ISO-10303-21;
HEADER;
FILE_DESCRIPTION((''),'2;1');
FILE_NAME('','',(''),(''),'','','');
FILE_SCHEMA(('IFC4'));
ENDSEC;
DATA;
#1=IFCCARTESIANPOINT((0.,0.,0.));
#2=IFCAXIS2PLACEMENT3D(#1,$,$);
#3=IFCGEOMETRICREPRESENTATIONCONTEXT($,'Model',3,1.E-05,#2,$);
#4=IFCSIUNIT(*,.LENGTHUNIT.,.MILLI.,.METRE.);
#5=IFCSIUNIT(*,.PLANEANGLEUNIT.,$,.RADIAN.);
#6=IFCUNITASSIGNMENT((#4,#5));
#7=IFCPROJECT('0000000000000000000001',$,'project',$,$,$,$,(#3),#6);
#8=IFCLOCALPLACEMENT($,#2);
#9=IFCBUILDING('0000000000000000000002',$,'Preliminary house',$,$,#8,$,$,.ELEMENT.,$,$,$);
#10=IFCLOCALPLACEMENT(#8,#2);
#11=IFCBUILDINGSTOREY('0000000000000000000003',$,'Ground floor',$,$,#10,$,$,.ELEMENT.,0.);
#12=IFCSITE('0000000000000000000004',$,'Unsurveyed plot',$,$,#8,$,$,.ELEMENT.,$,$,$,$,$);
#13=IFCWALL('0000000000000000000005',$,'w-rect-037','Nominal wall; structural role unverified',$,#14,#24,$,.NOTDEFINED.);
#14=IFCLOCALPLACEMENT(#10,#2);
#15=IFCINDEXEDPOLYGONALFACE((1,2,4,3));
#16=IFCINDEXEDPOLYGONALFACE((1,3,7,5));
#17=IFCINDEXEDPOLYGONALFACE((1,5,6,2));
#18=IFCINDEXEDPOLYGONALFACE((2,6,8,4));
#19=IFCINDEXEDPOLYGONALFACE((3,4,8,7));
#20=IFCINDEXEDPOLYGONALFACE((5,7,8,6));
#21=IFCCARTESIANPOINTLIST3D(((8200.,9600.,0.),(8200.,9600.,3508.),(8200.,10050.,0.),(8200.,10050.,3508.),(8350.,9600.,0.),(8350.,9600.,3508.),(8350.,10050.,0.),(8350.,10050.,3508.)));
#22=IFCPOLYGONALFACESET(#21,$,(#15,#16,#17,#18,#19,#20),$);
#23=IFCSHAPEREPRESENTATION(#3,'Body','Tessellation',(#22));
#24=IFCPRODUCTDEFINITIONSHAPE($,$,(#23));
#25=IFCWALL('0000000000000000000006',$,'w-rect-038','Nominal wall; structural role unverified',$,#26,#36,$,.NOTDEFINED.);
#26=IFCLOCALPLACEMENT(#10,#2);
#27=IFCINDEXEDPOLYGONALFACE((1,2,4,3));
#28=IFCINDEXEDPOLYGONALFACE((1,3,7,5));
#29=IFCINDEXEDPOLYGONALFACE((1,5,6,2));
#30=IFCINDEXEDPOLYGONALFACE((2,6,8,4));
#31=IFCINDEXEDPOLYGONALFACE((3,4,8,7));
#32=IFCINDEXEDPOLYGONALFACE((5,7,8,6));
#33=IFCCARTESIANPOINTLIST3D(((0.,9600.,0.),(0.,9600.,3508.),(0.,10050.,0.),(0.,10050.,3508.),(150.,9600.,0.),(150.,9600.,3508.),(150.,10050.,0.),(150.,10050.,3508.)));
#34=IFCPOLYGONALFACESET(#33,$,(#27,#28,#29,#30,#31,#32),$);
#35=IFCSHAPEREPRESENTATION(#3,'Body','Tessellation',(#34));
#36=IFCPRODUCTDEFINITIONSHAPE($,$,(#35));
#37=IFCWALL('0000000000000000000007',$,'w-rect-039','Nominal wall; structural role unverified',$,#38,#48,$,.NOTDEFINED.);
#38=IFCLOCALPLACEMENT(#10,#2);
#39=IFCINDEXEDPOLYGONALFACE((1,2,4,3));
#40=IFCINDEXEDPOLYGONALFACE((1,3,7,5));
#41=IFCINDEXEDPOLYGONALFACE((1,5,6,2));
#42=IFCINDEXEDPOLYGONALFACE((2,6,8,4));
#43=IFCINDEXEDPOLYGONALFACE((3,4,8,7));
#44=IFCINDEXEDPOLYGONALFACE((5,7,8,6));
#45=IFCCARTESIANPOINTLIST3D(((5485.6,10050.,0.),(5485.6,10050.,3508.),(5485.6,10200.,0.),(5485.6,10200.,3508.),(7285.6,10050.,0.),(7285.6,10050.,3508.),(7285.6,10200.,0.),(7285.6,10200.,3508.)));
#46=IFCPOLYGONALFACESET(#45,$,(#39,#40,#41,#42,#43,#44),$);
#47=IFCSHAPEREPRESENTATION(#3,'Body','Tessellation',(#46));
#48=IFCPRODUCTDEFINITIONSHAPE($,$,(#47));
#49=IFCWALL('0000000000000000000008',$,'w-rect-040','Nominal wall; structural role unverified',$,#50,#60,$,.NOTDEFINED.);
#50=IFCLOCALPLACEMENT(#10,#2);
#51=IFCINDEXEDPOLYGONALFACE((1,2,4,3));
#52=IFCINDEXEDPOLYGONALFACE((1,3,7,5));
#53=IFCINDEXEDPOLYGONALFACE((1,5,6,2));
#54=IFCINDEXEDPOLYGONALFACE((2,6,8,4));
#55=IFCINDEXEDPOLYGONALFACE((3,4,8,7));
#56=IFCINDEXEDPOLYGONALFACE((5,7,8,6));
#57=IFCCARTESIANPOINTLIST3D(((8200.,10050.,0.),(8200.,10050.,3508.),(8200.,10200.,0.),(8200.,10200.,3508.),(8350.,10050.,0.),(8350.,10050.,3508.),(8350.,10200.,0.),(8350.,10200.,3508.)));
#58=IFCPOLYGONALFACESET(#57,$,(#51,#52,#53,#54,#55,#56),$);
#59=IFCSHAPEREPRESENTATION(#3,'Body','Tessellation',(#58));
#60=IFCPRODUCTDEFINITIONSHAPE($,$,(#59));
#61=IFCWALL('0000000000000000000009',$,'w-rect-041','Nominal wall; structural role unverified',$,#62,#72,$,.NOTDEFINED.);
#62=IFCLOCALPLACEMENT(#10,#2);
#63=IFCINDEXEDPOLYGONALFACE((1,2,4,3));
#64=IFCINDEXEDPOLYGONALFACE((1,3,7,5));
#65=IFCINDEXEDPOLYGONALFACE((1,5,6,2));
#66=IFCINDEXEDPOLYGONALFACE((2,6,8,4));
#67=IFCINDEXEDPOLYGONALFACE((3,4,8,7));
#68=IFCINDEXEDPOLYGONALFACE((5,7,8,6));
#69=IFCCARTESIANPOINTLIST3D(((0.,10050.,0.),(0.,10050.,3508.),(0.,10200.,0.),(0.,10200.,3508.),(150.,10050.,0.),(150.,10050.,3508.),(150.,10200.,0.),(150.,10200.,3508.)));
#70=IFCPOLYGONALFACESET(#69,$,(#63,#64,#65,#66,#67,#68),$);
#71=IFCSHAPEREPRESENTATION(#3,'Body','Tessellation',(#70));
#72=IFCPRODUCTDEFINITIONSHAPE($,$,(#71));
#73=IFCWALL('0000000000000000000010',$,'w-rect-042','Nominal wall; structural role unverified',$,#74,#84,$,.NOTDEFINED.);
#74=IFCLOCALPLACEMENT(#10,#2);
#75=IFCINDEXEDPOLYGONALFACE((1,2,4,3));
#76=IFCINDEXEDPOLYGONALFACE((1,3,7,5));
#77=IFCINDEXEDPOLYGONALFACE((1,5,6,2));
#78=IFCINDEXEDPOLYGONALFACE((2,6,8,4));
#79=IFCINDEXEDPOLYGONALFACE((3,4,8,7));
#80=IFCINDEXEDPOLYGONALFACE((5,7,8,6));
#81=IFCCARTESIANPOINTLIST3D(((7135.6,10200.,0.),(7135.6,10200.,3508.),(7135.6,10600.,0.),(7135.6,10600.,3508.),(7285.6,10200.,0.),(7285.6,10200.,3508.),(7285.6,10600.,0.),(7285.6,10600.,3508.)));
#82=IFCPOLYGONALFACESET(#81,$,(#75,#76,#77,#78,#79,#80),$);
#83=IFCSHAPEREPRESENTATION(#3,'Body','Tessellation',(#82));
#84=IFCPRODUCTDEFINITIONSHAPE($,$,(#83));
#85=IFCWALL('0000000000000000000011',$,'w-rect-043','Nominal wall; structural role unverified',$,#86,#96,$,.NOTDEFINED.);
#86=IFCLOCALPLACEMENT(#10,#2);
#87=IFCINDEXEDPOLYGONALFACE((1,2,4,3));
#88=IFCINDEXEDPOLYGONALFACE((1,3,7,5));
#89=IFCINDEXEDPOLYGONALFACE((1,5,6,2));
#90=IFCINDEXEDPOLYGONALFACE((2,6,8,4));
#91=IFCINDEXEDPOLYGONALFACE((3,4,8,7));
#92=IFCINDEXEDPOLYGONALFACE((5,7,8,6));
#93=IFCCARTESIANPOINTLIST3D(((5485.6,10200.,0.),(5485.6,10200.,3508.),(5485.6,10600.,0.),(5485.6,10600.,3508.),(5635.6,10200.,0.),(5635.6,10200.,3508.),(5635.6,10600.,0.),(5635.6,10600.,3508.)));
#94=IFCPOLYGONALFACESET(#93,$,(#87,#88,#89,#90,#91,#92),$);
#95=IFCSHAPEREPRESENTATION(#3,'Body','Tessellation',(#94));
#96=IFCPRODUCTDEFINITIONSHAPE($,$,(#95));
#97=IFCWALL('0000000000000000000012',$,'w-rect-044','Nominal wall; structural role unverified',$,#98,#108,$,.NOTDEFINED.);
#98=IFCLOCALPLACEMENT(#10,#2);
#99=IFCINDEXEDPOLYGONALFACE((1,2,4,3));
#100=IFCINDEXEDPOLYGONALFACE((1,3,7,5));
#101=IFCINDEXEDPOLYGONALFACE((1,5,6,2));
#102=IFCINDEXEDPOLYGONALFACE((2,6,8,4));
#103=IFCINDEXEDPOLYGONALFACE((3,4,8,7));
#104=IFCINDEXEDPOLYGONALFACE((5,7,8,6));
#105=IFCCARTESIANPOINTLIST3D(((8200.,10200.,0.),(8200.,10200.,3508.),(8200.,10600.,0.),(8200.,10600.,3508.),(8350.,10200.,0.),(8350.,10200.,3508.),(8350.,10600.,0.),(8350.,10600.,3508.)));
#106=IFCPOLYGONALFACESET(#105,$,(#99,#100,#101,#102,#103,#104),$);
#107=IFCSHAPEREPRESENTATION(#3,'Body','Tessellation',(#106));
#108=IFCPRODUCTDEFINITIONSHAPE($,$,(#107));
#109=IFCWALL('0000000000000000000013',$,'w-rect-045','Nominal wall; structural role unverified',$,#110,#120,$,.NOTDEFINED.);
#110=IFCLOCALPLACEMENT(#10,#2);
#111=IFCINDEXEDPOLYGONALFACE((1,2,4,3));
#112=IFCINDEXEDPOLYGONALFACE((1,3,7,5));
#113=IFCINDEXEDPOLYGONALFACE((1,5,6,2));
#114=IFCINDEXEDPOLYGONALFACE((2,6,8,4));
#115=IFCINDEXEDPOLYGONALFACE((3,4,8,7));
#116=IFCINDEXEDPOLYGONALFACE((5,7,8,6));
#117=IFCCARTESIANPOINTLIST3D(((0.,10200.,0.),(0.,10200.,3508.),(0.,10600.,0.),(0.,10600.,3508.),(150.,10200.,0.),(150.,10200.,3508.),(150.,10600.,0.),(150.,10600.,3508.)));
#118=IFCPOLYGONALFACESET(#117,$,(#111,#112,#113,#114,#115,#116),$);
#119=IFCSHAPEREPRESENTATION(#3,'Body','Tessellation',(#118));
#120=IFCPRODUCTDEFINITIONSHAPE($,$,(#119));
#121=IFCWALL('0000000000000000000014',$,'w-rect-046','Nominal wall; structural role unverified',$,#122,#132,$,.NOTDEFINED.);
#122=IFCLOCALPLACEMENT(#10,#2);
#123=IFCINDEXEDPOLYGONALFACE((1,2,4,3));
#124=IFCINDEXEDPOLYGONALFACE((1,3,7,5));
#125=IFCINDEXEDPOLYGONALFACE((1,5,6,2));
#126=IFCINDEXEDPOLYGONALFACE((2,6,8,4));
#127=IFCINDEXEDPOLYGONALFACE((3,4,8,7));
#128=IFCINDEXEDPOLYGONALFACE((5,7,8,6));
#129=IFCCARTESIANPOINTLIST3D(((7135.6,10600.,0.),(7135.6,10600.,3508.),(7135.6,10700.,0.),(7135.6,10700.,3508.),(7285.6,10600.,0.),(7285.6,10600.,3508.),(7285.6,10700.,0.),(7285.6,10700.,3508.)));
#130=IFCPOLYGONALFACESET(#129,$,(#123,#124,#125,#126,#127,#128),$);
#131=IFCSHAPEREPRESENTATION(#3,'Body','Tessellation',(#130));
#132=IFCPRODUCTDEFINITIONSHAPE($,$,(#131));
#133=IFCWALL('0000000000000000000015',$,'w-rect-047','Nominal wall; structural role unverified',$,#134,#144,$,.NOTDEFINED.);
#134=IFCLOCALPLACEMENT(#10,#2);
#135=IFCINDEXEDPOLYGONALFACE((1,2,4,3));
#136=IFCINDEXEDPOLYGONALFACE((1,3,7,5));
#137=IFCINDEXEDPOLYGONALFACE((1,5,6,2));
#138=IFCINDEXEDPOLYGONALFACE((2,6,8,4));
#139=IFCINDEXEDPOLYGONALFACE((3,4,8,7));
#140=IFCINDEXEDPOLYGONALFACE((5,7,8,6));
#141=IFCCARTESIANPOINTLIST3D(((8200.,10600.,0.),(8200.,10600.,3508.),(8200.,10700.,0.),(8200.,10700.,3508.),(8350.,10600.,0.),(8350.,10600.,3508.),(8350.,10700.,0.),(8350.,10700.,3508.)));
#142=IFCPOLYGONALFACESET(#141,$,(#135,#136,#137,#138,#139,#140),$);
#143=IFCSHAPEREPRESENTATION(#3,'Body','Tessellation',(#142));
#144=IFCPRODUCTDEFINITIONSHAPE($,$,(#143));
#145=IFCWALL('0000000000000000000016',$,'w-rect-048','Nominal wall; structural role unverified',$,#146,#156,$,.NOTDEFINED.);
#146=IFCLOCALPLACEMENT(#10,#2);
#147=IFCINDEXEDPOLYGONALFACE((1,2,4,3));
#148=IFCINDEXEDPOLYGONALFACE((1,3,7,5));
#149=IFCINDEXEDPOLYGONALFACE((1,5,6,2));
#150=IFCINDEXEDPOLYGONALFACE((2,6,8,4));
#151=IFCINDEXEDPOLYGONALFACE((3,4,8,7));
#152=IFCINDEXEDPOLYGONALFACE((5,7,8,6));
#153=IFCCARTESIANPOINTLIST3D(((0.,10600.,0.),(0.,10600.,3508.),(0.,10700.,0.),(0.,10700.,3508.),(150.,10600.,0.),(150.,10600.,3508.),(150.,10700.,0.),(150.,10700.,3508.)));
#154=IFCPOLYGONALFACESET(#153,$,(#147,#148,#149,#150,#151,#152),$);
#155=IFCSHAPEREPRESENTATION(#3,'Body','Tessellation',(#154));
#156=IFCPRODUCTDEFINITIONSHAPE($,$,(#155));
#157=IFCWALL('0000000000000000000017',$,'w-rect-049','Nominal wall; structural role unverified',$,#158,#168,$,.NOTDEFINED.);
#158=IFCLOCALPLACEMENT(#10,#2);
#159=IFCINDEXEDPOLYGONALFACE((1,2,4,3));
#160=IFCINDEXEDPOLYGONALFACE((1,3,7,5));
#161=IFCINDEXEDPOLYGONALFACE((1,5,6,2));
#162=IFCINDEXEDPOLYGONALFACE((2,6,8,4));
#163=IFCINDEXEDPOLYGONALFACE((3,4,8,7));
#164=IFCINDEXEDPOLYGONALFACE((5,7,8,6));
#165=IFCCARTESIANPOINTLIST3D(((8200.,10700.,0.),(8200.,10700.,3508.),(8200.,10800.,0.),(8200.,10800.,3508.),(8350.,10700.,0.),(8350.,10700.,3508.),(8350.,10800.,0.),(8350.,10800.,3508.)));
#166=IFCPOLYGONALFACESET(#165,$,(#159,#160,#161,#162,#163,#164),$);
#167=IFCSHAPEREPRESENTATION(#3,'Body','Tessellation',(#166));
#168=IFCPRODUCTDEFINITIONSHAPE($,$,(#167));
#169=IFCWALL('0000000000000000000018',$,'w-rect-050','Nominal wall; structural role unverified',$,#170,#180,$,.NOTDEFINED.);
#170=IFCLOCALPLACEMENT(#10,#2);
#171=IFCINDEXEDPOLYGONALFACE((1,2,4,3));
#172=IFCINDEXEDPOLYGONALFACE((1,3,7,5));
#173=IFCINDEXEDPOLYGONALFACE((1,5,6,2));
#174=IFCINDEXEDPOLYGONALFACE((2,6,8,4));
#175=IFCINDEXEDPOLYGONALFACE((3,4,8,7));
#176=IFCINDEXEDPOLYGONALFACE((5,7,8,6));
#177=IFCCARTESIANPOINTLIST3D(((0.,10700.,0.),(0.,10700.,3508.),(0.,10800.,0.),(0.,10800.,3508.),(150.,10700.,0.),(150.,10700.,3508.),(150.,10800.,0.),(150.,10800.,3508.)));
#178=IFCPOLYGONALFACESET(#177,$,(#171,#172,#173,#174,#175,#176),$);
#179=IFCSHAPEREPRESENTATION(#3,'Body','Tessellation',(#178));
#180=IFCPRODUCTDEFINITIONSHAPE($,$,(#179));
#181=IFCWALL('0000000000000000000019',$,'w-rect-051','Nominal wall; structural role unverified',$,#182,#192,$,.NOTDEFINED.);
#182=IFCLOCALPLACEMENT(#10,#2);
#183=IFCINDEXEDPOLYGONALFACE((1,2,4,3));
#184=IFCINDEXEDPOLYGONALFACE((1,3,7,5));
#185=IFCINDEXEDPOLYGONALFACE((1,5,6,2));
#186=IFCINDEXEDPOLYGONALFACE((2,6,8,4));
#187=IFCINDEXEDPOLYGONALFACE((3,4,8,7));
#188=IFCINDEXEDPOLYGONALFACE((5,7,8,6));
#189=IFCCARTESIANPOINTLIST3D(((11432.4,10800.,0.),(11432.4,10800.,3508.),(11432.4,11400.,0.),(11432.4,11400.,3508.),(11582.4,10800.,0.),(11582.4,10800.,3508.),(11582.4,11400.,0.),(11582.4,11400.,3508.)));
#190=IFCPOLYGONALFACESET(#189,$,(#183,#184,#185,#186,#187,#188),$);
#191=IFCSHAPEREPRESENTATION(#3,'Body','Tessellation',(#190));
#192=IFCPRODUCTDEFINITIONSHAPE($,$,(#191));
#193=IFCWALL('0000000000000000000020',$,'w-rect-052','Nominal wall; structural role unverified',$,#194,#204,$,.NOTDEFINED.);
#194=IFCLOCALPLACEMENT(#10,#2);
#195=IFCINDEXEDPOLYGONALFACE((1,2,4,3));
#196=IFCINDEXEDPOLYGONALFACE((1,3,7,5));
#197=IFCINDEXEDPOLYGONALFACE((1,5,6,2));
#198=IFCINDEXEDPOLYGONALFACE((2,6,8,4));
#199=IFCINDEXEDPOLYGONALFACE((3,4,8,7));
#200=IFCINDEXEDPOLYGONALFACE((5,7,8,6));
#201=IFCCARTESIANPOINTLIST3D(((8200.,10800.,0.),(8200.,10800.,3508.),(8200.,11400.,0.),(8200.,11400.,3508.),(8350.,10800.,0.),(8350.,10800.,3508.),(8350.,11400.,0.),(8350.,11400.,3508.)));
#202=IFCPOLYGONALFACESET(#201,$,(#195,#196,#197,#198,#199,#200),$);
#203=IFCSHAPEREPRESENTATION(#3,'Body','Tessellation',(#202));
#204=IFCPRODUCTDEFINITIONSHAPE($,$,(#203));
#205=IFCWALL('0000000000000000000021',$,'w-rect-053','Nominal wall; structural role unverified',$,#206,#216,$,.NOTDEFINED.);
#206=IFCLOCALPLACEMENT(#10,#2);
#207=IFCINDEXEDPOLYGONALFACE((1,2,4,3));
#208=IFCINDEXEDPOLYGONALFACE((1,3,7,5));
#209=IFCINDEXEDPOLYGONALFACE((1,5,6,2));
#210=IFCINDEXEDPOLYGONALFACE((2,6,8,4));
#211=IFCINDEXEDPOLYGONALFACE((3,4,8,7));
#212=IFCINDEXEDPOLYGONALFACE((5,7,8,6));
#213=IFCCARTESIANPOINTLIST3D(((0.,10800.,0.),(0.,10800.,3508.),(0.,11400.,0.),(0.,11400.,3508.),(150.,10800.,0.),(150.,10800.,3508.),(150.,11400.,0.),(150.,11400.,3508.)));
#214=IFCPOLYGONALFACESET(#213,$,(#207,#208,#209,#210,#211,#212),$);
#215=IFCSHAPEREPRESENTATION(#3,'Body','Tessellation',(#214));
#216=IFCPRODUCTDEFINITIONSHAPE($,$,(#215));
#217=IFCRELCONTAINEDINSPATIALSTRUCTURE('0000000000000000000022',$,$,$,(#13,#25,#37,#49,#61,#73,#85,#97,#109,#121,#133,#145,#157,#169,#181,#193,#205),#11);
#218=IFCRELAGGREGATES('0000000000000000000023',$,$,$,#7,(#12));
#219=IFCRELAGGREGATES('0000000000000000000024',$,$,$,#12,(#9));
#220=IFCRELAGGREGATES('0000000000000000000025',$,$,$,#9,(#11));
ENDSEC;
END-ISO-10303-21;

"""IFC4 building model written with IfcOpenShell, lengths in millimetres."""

from ifc_helpers import new_model, si_unit, origin, place, context, project, spatial, polyline, outline, extrude, element, save


model = new_model("IFC4")

# Units and contexts
model_context = context("Model", 3, precision=1e-05, world=origin())
ifc_project = project(units=[si_unit("LENGTHUNIT", "METRE", prefix="MILLI"), si_unit("PLANEANGLEUNIT", "RADIAN")], contexts=[model_context])

# Site, building, storey
placement_1 = place(None, origin())
site = spatial("IfcSite", under=ifc_project, at=placement_1, Name="Unsurveyed plot", CompositionType="ELEMENT")
building = spatial("IfcBuilding", under=site, at=placement_1, Name="Preliminary house", CompositionType="ELEMENT")
placement_2 = place(placement_1, origin())
storey = spatial("IfcBuildingStorey", under=building, at=placement_2, Name="Ground floor", CompositionType="ELEMENT", Elevation=0.0)

# Walls
element("IfcWall", 1, at=placement_2, inside=storey, Name="w-rect-037", Description="Nominal wall; structural role unverified", PredefinedType="NOTDEFINED", context=model_context, shape_type="SweptSolid", body=[
    extrude(outline(polyline([(8200.0, 9600.0), (8350.0, 9600.0), (8350.0, 10050.0), (8200.0, 10050.0), (8200.0, 9600.0)])), origin(), (0.0, 0.0, 1.0), 3508.0),
])
element("IfcWall", 2, at=placement_2, inside=storey, Name="w-rect-038", Description="Nominal wall; structural role unverified", PredefinedType="NOTDEFINED", context=model_context, shape_type="SweptSolid", body=[
    extrude(outline(polyline([(0.0, 9600.0), (150.0, 9600.0), (150.0, 10050.0), (0.0, 10050.0), (0.0, 9600.0)])), origin(), (0.0, 0.0, 1.0), 3508.0),
])
element("IfcWall", 3, at=placement_2, inside=storey, Name="w-rect-039", Description="Nominal wall; structural role unverified", PredefinedType="NOTDEFINED", context=model_context, shape_type="SweptSolid", body=[
    extrude(outline(polyline([(5485.6, 10050.0), (7285.6, 10050.0), (7285.6, 10200.0), (5485.6, 10200.0), (5485.6, 10050.0)])), origin(), (0.0, 0.0, 1.0), 3508.0),
])
element("IfcWall", 4, at=placement_2, inside=storey, Name="w-rect-040", Description="Nominal wall; structural role unverified", PredefinedType="NOTDEFINED", context=model_context, shape_type="SweptSolid", body=[
    extrude(outline(polyline([(8200.0, 10050.0), (8350.0, 10050.0), (8350.0, 10200.0), (8200.0, 10200.0), (8200.0, 10050.0)])), origin(), (0.0, 0.0, 1.0), 3508.0),
])
element("IfcWall", 5, at=placement_2, inside=storey, Name="w-rect-041", Description="Nominal wall; structural role unverified", PredefinedType="NOTDEFINED", context=model_context, shape_type="SweptSolid", body=[
    extrude(outline(polyline([(0.0, 10050.0), (150.0, 10050.0), (150.0, 10200.0), (0.0, 10200.0), (0.0, 10050.0)])), origin(), (0.0, 0.0, 1.0), 3508.0),
])
element("IfcWall", 6, at=placement_2, inside=storey, Name="w-rect-042", Description="Nominal wall; structural role unverified", PredefinedType="NOTDEFINED", context=model_context, shape_type="SweptSolid", body=[
    extrude(outline(polyline([(7135.6, 10200.0), (7285.6, 10200.0), (7285.6, 10600.0), (7135.6, 10600.0), (7135.6, 10200.0)])), origin(), (0.0, 0.0, 1.0), 3508.0),
])
element("IfcWall", 7, at=placement_2, inside=storey, Name="w-rect-043", Description="Nominal wall; structural role unverified", PredefinedType="NOTDEFINED", context=model_context, shape_type="SweptSolid", body=[
    extrude(outline(polyline([(5485.6, 10200.0), (5635.6, 10200.0), (5635.6, 10600.0), (5485.6, 10600.0), (5485.6, 10200.0)])), origin(), (0.0, 0.0, 1.0), 3508.0),
])
element("IfcWall", 8, at=placement_2, inside=storey, Name="w-rect-044", Description="Nominal wall; structural role unverified", PredefinedType="NOTDEFINED", context=model_context, shape_type="SweptSolid", body=[
    extrude(outline(polyline([(8200.0, 10200.0), (8350.0, 10200.0), (8350.0, 10600.0), (8200.0, 10600.0), (8200.0, 10200.0)])), origin(), (0.0, 0.0, 1.0), 3508.0),
])
element("IfcWall", 9, at=placement_2, inside=storey, Name="w-rect-045", Description="Nominal wall; structural role unverified", PredefinedType="NOTDEFINED", context=model_context, shape_type="SweptSolid", body=[
    extrude(outline(polyline([(0.0, 10200.0), (150.0, 10200.0), (150.0, 10600.0), (0.0, 10600.0), (0.0, 10200.0)])), origin(), (0.0, 0.0, 1.0), 3508.0),
])
element("IfcWall", 10, at=placement_2, inside=storey, Name="w-rect-046", Description="Nominal wall; structural role unverified", PredefinedType="NOTDEFINED", context=model_context, shape_type="SweptSolid", body=[
    extrude(outline(polyline([(7135.6, 10600.0), (7285.6, 10600.0), (7285.6, 10700.0), (7135.6, 10700.0), (7135.6, 10600.0)])), origin(), (0.0, 0.0, 1.0), 3508.0),
])
element("IfcWall", 11, at=placement_2, inside=storey, Name="w-rect-047", Description="Nominal wall; structural role unverified", PredefinedType="NOTDEFINED", context=model_context, shape_type="SweptSolid", body=[
    extrude(outline(polyline([(8200.0, 10600.0), (8350.0, 10600.0), (8350.0, 10700.0), (8200.0, 10700.0), (8200.0, 10600.0)])), origin(), (0.0, 0.0, 1.0), 3508.0),
])
element("IfcWall", 12, at=placement_2, inside=storey, Name="w-rect-048", Description="Nominal wall; structural role unverified", PredefinedType="NOTDEFINED", context=model_context, shape_type="SweptSolid", body=[
    extrude(outline(polyline([(0.0, 10600.0), (150.0, 10600.0), (150.0, 10700.0), (0.0, 10700.0), (0.0, 10600.0)])), origin(), (0.0, 0.0, 1.0), 3508.0),
])
element("IfcWall", 13, at=placement_2, inside=storey, Name="w-rect-049", Description="Nominal wall; structural role unverified", PredefinedType="NOTDEFINED", context=model_context, shape_type="SweptSolid", body=[
    extrude(outline(polyline([(8200.0, 10700.0), (8350.0, 10700.0), (8350.0, 10800.0), (8200.0, 10800.0), (8200.0, 10700.0)])), origin(), (0.0, 0.0, 1.0), 3508.0),
])
element("IfcWall", 14, at=placement_2, inside=storey, Name="w-rect-050", Description="Nominal wall; structural role unverified", PredefinedType="NOTDEFINED", context=model_context, shape_type="SweptSolid", body=[
    extrude(outline(polyline([(0.0, 10700.0), (150.0, 10700.0), (150.0, 10800.0), (0.0, 10800.0), (0.0, 10700.0)])), origin(), (0.0, 0.0, 1.0), 3508.0),
])
element("IfcWall", 15, at=placement_2, inside=storey, Name="w-rect-051", Description="Nominal wall; structural role unverified", PredefinedType="NOTDEFINED", context=model_context, shape_type="SweptSolid", body=[
    extrude(outline(polyline([(11432.4, 10800.0), (11582.4, 10800.0), (11582.4, 11400.0), (11432.4, 11400.0), (11432.4, 10800.0)])), origin(), (0.0, 0.0, 1.0), 3508.0),
])
element("IfcWall", 16, at=placement_2, inside=storey, Name="w-rect-052", Description="Nominal wall; structural role unverified", PredefinedType="NOTDEFINED", context=model_context, shape_type="SweptSolid", body=[
    extrude(outline(polyline([(8200.0, 10800.0), (8350.0, 10800.0), (8350.0, 11400.0), (8200.0, 11400.0), (8200.0, 10800.0)])), origin(), (0.0, 0.0, 1.0), 3508.0),
])
element("IfcWall", 17, at=placement_2, inside=storey, Name="w-rect-053", Description="Nominal wall; structural role unverified", PredefinedType="NOTDEFINED", context=model_context, shape_type="SweptSolid", body=[
    extrude(outline(polyline([(0.0, 10800.0), (150.0, 10800.0), (150.0, 11400.0), (0.0, 11400.0), (0.0, 10800.0)])), origin(), (0.0, 0.0, 1.0), 3508.0),
])

save(model, "model.ifc")
